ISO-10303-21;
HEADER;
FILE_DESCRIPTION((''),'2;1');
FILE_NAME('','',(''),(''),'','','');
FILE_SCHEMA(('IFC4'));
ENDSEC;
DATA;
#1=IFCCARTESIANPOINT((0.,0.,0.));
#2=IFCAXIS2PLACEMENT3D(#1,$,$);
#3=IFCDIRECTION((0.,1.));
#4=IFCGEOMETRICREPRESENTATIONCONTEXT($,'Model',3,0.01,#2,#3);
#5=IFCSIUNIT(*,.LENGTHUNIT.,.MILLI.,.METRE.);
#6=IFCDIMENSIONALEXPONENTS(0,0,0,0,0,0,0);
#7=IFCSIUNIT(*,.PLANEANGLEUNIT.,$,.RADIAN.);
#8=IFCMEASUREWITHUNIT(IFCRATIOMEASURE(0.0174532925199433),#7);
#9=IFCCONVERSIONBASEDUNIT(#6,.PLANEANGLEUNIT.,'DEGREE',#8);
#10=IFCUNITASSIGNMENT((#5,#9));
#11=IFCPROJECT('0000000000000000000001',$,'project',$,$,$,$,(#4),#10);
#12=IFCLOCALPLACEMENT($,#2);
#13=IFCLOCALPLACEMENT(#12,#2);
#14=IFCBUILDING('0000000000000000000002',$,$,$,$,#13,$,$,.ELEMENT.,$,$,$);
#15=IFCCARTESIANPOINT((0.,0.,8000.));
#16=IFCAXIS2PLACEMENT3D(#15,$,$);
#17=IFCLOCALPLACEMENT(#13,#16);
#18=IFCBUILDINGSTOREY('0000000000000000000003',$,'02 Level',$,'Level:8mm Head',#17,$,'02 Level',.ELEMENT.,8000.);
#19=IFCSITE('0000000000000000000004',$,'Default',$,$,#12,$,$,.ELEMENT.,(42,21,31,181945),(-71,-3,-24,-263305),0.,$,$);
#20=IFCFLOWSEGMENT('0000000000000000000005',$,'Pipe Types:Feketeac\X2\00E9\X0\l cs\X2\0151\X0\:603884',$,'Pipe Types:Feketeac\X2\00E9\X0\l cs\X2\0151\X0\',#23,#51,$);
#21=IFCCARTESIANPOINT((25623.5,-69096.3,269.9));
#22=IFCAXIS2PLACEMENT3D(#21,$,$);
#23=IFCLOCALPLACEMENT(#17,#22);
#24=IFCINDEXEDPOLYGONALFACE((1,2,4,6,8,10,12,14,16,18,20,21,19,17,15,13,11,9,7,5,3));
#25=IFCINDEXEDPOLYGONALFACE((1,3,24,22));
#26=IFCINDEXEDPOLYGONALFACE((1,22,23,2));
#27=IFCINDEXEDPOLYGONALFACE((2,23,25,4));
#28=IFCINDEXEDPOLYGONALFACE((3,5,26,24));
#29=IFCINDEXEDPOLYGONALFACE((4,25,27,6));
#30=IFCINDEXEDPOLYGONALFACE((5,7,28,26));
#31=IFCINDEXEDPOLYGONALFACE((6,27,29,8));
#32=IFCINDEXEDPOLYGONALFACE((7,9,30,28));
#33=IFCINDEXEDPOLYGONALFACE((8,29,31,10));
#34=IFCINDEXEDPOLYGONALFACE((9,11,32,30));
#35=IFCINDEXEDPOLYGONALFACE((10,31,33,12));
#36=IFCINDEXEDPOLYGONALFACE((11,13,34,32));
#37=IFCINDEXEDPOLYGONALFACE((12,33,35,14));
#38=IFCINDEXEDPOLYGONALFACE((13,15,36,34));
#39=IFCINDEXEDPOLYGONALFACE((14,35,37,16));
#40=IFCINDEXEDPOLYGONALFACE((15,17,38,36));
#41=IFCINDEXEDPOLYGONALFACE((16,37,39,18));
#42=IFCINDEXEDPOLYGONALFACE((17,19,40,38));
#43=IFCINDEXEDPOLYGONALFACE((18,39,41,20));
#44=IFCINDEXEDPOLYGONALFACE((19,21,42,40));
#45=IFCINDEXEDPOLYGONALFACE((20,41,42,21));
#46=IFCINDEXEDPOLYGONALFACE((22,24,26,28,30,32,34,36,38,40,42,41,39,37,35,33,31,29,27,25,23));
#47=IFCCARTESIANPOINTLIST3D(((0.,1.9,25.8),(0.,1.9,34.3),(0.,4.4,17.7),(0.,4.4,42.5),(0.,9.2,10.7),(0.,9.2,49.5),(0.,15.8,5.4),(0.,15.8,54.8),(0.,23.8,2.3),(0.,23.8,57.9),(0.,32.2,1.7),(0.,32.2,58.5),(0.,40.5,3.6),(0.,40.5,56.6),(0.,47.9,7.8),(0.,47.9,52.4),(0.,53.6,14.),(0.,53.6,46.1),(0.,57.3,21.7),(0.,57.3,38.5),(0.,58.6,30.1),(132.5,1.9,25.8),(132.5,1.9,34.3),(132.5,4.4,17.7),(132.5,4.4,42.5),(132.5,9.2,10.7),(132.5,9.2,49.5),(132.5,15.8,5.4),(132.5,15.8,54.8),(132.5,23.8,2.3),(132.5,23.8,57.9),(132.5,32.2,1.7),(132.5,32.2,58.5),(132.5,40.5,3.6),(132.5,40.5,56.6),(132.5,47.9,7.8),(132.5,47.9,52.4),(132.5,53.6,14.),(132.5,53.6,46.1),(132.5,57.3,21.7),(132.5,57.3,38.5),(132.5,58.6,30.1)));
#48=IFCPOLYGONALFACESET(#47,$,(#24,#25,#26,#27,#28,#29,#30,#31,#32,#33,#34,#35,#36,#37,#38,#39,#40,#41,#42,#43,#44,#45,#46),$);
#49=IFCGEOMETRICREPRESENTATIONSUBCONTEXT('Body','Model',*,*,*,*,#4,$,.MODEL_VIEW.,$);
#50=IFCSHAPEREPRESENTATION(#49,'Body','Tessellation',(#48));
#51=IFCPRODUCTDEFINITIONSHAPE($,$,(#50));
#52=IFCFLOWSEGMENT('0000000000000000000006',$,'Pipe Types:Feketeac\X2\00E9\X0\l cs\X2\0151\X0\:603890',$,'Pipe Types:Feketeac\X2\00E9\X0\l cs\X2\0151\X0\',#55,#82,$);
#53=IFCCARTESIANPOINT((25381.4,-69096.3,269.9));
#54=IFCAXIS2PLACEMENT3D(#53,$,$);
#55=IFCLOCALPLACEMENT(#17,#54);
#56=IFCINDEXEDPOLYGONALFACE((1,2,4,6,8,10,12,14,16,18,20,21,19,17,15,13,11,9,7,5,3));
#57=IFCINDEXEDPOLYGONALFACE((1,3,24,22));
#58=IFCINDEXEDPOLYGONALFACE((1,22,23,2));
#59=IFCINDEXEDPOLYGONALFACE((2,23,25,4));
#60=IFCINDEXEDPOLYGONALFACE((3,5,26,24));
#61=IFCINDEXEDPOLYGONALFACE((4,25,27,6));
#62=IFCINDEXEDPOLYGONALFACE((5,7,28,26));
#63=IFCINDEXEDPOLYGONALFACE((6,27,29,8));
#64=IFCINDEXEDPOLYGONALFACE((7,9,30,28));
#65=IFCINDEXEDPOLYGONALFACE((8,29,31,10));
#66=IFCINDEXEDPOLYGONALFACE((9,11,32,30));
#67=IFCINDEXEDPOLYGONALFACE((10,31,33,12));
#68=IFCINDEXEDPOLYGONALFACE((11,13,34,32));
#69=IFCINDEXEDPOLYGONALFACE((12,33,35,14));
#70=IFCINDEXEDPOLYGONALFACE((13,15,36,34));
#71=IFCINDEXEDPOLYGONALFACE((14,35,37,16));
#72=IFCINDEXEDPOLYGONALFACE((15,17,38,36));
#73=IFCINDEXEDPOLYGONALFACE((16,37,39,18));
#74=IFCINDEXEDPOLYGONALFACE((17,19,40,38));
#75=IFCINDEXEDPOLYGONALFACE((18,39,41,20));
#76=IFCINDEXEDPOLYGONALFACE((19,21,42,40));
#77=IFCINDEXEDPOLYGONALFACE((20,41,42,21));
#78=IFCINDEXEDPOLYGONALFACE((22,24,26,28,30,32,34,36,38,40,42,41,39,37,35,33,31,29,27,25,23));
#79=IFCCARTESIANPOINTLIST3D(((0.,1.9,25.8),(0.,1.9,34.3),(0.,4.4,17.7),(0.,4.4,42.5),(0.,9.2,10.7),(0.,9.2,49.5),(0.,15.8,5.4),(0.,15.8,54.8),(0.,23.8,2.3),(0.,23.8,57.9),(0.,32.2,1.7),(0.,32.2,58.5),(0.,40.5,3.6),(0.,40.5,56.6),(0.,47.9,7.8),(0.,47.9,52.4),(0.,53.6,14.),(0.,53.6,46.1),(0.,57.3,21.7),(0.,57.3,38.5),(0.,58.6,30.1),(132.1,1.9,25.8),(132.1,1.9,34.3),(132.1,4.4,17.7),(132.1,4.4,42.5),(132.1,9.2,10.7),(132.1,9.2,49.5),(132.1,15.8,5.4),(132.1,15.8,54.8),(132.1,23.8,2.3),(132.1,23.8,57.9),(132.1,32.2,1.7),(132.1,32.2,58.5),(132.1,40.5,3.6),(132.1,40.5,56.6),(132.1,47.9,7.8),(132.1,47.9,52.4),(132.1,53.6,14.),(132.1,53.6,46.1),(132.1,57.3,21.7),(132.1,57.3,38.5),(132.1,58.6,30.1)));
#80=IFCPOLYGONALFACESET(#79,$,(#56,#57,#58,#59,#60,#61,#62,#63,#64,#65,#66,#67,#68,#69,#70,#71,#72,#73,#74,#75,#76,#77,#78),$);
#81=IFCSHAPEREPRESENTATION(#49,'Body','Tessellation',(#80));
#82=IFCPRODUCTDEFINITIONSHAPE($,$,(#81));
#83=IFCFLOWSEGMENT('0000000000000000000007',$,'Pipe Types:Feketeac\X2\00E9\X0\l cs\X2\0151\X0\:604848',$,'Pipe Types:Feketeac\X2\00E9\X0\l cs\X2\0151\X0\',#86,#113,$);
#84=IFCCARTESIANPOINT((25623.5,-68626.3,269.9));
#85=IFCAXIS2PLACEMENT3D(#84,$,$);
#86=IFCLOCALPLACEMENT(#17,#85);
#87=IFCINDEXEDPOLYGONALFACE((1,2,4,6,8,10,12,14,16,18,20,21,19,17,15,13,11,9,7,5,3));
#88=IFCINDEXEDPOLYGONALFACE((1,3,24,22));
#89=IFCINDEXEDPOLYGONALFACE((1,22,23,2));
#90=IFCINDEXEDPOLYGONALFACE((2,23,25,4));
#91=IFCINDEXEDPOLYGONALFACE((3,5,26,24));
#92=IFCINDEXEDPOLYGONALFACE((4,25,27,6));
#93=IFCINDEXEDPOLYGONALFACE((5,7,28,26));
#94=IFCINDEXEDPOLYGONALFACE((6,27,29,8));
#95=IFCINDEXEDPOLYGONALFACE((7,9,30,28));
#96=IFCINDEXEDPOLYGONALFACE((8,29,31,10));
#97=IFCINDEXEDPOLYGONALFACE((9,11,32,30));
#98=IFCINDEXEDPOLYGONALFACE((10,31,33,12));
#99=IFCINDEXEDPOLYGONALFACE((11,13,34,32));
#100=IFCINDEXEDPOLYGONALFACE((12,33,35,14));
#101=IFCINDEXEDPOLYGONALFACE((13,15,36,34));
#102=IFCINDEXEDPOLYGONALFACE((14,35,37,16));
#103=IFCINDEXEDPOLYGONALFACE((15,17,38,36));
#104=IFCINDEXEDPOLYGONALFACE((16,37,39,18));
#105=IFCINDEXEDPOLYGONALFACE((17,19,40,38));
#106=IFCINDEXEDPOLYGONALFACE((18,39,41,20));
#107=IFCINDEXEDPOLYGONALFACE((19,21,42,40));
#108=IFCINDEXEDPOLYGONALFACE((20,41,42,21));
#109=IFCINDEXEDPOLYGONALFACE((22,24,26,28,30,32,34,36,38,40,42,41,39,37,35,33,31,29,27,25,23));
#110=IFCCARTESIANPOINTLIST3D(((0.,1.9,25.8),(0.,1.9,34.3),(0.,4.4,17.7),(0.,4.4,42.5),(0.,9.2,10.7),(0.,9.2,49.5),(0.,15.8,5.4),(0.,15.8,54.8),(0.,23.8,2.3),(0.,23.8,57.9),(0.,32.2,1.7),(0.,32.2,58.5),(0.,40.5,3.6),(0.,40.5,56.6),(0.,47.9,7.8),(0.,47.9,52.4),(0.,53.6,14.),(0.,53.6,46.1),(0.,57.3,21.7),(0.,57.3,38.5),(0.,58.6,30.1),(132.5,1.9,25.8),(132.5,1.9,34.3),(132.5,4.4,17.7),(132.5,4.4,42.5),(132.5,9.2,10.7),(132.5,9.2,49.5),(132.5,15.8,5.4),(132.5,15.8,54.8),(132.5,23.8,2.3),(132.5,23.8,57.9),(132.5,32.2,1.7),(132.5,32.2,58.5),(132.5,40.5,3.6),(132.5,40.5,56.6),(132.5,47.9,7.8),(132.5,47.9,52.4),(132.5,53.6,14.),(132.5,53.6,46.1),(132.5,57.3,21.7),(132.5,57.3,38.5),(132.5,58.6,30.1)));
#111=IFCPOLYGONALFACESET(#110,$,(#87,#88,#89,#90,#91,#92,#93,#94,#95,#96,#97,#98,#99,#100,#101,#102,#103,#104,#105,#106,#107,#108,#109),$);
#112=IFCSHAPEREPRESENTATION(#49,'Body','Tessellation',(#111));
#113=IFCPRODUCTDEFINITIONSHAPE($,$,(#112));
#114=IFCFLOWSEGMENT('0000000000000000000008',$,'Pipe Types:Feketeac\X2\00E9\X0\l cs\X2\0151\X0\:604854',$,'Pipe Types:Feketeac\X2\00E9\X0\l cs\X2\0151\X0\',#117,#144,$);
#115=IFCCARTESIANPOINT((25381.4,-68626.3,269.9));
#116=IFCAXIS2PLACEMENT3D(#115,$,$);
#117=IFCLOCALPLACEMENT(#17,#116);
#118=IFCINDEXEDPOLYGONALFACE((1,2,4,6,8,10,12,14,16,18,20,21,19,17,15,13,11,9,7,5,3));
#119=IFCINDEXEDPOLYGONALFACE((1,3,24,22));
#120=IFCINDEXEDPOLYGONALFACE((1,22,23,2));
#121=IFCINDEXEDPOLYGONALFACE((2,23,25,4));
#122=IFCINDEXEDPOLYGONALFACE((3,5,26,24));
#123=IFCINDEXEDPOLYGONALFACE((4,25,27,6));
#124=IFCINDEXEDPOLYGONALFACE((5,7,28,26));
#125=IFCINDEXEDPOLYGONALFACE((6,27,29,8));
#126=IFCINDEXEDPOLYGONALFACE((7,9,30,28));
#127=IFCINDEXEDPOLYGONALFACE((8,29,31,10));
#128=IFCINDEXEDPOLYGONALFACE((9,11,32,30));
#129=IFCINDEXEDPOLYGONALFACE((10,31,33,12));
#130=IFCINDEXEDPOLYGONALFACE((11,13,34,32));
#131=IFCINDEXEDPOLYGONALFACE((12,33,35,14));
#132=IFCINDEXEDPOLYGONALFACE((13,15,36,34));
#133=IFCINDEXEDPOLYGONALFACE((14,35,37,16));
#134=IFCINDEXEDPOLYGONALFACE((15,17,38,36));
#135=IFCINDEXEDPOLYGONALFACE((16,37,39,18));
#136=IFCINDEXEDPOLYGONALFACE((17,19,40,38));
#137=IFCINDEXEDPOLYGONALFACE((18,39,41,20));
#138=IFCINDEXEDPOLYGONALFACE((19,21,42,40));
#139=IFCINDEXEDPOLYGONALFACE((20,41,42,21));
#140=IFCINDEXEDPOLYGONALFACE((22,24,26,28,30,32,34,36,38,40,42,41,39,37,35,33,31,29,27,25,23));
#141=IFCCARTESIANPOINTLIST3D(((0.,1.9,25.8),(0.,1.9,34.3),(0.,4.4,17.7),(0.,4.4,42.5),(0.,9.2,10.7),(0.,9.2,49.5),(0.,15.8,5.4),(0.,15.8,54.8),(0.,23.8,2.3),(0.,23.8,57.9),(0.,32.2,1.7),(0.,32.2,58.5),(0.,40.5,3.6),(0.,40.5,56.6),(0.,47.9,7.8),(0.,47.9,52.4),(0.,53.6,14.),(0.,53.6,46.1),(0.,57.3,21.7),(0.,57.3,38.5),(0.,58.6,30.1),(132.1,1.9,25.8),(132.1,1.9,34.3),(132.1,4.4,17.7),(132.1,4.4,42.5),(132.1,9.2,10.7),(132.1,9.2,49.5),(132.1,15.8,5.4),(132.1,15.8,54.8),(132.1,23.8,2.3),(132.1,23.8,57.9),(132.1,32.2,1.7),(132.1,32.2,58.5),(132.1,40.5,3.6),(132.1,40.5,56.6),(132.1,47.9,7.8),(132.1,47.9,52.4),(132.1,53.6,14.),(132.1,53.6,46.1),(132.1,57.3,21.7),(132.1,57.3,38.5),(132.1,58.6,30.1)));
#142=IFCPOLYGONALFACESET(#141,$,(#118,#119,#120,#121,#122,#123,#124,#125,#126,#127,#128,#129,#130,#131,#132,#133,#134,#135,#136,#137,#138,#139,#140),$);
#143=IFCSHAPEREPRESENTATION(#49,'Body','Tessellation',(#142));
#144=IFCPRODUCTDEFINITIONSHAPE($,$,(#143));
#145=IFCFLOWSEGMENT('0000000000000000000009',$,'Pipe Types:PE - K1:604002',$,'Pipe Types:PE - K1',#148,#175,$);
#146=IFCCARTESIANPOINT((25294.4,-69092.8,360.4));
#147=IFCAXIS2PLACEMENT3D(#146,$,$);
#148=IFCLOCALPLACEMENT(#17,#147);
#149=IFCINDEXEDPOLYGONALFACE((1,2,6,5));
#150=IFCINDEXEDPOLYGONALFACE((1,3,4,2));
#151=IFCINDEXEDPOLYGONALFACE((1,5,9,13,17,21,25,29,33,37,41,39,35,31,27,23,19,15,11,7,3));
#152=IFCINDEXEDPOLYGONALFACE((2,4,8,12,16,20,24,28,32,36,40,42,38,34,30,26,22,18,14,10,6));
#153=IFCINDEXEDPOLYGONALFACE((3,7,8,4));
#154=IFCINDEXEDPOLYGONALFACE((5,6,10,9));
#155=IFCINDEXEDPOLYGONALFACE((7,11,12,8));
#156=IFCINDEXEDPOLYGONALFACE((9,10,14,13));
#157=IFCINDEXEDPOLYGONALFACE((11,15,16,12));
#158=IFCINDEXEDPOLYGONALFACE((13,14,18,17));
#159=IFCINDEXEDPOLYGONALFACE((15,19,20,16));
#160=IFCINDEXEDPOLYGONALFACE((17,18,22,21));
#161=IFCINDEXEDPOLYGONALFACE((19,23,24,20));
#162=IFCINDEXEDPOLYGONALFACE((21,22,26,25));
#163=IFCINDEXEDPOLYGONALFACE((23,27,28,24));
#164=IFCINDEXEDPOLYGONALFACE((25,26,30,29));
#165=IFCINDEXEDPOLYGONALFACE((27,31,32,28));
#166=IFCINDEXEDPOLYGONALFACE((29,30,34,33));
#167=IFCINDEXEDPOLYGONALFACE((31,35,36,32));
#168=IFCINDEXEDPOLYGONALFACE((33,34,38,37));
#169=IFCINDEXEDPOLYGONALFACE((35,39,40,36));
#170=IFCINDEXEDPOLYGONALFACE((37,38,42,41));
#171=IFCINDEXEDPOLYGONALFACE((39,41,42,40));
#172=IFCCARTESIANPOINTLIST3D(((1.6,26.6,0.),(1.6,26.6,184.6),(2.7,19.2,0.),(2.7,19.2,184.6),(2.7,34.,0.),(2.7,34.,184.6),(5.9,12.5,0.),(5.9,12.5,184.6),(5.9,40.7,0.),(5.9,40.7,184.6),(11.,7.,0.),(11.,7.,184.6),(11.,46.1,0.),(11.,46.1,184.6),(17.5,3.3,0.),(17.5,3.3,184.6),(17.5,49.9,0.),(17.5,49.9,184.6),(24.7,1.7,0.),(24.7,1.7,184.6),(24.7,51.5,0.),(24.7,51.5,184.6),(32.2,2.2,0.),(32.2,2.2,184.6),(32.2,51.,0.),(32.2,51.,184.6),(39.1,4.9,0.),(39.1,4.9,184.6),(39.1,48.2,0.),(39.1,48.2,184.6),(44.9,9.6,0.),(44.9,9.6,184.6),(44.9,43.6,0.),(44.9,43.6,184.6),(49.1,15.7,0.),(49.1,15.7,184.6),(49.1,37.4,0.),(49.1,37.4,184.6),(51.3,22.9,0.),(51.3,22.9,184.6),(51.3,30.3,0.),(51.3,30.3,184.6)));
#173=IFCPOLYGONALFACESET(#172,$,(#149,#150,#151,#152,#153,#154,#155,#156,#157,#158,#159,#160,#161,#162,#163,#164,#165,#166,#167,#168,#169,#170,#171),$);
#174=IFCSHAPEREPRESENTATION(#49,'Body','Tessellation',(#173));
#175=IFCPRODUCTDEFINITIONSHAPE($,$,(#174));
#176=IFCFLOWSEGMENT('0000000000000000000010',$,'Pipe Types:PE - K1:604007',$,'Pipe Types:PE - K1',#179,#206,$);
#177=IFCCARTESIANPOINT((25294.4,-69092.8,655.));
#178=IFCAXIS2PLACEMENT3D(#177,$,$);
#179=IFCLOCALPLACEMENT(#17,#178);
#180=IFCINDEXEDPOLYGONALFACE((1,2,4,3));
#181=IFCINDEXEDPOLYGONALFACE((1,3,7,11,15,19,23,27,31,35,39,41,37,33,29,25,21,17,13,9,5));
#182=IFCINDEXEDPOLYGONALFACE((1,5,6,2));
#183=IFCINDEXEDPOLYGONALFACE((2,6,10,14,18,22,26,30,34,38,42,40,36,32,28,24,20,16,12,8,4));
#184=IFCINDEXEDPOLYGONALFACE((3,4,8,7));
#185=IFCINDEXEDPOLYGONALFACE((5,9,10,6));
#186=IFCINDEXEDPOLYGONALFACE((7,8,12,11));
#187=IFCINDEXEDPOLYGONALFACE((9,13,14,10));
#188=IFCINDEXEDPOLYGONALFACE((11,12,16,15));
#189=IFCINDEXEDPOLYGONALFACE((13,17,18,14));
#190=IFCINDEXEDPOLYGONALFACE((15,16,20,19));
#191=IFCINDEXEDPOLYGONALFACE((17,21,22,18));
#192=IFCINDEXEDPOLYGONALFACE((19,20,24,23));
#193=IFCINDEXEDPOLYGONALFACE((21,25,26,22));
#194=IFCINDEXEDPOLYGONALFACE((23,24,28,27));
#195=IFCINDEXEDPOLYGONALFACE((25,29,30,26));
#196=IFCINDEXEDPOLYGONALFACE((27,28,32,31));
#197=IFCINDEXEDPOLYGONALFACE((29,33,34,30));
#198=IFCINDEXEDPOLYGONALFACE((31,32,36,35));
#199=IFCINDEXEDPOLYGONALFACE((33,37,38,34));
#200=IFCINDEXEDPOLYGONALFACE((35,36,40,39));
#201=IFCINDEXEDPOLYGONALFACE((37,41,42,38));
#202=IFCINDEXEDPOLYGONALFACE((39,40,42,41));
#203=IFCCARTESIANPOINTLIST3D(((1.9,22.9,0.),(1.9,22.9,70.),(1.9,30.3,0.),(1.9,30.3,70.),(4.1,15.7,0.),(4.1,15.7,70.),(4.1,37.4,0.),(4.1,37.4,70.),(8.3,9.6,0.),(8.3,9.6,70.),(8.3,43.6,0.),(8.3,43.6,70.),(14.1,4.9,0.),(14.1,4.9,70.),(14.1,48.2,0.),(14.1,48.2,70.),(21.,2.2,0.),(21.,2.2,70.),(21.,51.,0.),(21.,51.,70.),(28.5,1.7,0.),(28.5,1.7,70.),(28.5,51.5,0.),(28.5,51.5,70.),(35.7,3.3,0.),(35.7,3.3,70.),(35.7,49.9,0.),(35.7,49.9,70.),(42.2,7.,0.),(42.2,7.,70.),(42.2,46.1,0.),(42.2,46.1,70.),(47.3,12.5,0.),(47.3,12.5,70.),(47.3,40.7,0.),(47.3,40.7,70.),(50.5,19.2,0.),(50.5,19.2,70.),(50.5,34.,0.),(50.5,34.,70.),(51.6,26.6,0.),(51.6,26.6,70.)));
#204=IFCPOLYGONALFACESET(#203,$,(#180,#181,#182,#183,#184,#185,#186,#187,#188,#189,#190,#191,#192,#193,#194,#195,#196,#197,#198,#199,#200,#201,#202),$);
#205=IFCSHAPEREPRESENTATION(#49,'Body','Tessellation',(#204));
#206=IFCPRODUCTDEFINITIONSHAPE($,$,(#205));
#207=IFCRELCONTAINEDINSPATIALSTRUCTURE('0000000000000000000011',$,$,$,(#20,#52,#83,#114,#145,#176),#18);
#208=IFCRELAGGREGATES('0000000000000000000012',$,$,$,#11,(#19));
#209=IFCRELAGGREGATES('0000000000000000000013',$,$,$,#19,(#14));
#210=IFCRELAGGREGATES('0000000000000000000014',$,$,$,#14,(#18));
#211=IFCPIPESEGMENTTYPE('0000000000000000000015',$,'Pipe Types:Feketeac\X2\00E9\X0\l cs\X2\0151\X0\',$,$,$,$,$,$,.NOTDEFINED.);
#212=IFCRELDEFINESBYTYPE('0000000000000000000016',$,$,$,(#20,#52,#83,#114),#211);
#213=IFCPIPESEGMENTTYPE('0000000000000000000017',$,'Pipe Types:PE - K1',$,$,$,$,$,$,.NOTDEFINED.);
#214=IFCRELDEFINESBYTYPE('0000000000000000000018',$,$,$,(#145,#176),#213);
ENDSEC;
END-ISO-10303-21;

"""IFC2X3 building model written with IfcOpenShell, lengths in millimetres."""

from ifc_helpers import new_model, entity, si_unit, converted_unit, direction, frame, frame_2d, origin, origin_2d_with_axis, place, context, subcontext, project, spatial, circle, extrude, type_object, element, save


model = new_model("IFC2X3")

# Units and contexts
model_context = context("Model", 3, precision=0.01, world=origin(), true_north=direction((0.0, 1.0)))
body_context = subcontext(model_context, "Body", "Model", "MODEL_VIEW")
ifc_project = project(units=[si_unit("LENGTHUNIT", "METRE", prefix="MILLI"), converted_unit("PLANEANGLEUNIT", "DEGREE", entity("IfcRatioMeasure", 0.0174532925199433), si_unit("PLANEANGLEUNIT", "RADIAN"), dimensions=[0, 0, 0, 0, 0, 0, 0])], contexts=[model_context])

# Site, building, storey
site_placement = place(None, origin())
site = spatial("IfcSite", under=ifc_project, at=site_placement, Name="Default", CompositionType="ELEMENT", RefLatitude=(42, 21, 31, 181945), RefLongitude=(-71, -3, -24, -263305), RefElevation=0.0)
building_placement = place(site_placement, origin())
building = spatial("IfcBuilding", under=site, at=building_placement, CompositionType="ELEMENT")
storey_placement = place(building_placement, frame((0.0, 0.0, 8000.0)))
storey = spatial("IfcBuildingStorey", under=building, at=storey_placement, Name="02 Level", ObjectType="Level:8mm Head", LongName="02 Level", CompositionType="ELEMENT", Elevation=8000.0)

# Flow segments
pipe_segment_type_1 = type_object("IfcPipeSegmentType", Name="Pipe Types:Feketeacél cső", PredefinedType="NOTDEFINED")
flow_segment_1_placement = place(storey_placement, frame((25623.5, -69096.3, 269.9)))
element("IfcFlowSegment", 1, at=flow_segment_1_placement, inside=storey, type_object=pipe_segment_type_1, Name="Pipe Types:Feketeacél cső:603884", ObjectType="Pipe Types:Feketeacél cső", context=body_context, shape_type="SweptSolid", body=[
    extrude(circle(Radius=28.5, at=frame_2d((0.0, 0.0), x_axis=(1.0, 0.0))), frame((0.0, 30.1, 30.1), z_axis=(1.0, 0.0, 0.0), x_axis=(0.0, 1.0, 0.0)), (0.0, 0.0, 1.0), 132.5),
])
flow_segment_2_placement = place(storey_placement, frame((25381.4, -69096.3, 269.9)))
element("IfcFlowSegment", 2, at=flow_segment_2_placement, inside=storey, type_object=pipe_segment_type_1, Name="Pipe Types:Feketeacél cső:603890", ObjectType="Pipe Types:Feketeacél cső", context=body_context, shape_type="SweptSolid", body=[
    extrude(circle(Radius=28.5, at=origin_2d_with_axis()), frame((0.0, 30.1, 30.1), z_axis=(1.0, 0.0, 0.0), x_axis=(0.0, 1.0, 0.0)), (0.0, 0.0, 1.0), 132.1),
])
flow_segment_3_placement = place(storey_placement, frame((25623.5, -68626.3, 269.9)))
element("IfcFlowSegment", 3, at=flow_segment_3_placement, inside=storey, type_object=pipe_segment_type_1, Name="Pipe Types:Feketeacél cső:604848", ObjectType="Pipe Types:Feketeacél cső", context=body_context, shape_type="SweptSolid", body=[
    extrude(circle(Radius=28.5, at=frame_2d((0.0, 0.0), x_axis=(1.0, 0.0))), frame((0.0, 30.1, 30.1), z_axis=(1.0, 0.0, 0.0), x_axis=(0.0, 1.0, 0.0)), (0.0, 0.0, 1.0), 132.5),
])
flow_segment_4_placement = place(storey_placement, frame((25381.4, -68626.3, 269.9)))
element("IfcFlowSegment", 4, at=flow_segment_4_placement, inside=storey, type_object=pipe_segment_type_1, Name="Pipe Types:Feketeacél cső:604854", ObjectType="Pipe Types:Feketeacél cső", context=body_context, shape_type="SweptSolid", body=[
    extrude(circle(Radius=28.5, at=origin_2d_with_axis()), frame((0.0, 30.1, 30.1), z_axis=(1.0, 0.0, 0.0), x_axis=(0.0, 1.0, 0.0)), (0.0, 0.0, 1.0), 132.1),
])
pipe_segment_type_2 = type_object("IfcPipeSegmentType", Name="Pipe Types:PE - K1", PredefinedType="NOTDEFINED")
flow_segment_5_placement = place(storey_placement, frame((25294.4, -69092.8, 360.4)))
element("IfcFlowSegment", 5, at=flow_segment_5_placement, inside=storey, type_object=pipe_segment_type_2, Name="Pipe Types:PE - K1:604002", ObjectType="Pipe Types:PE - K1", context=body_context, shape_type="SweptSolid", body=[
    extrude(circle(Radius=25.0, at=origin_2d_with_axis()), frame((26.6, 26.6, 0.0), z_axis=(0.0, 0.0, 1.0), x_axis=(-1.0, 0.0, 0.0)), (0.0, 0.0, 1.0), 184.6),
])
flow_segment_6_placement = place(storey_placement, frame((25294.4, -69092.8, 655.0)))
element("IfcFlowSegment", 6, at=flow_segment_6_placement, inside=storey, type_object=pipe_segment_type_2, Name="Pipe Types:PE - K1:604007", ObjectType="Pipe Types:PE - K1", context=body_context, shape_type="SweptSolid", body=[
    extrude(circle(Radius=25.0, at=frame_2d((0.0, 0.0), x_axis=(1.0, 0.0))), frame((26.6, 26.6, 0.0)), (0.0, 0.0, 1.0), 70.0),
])

save(model, "model.ifc")
